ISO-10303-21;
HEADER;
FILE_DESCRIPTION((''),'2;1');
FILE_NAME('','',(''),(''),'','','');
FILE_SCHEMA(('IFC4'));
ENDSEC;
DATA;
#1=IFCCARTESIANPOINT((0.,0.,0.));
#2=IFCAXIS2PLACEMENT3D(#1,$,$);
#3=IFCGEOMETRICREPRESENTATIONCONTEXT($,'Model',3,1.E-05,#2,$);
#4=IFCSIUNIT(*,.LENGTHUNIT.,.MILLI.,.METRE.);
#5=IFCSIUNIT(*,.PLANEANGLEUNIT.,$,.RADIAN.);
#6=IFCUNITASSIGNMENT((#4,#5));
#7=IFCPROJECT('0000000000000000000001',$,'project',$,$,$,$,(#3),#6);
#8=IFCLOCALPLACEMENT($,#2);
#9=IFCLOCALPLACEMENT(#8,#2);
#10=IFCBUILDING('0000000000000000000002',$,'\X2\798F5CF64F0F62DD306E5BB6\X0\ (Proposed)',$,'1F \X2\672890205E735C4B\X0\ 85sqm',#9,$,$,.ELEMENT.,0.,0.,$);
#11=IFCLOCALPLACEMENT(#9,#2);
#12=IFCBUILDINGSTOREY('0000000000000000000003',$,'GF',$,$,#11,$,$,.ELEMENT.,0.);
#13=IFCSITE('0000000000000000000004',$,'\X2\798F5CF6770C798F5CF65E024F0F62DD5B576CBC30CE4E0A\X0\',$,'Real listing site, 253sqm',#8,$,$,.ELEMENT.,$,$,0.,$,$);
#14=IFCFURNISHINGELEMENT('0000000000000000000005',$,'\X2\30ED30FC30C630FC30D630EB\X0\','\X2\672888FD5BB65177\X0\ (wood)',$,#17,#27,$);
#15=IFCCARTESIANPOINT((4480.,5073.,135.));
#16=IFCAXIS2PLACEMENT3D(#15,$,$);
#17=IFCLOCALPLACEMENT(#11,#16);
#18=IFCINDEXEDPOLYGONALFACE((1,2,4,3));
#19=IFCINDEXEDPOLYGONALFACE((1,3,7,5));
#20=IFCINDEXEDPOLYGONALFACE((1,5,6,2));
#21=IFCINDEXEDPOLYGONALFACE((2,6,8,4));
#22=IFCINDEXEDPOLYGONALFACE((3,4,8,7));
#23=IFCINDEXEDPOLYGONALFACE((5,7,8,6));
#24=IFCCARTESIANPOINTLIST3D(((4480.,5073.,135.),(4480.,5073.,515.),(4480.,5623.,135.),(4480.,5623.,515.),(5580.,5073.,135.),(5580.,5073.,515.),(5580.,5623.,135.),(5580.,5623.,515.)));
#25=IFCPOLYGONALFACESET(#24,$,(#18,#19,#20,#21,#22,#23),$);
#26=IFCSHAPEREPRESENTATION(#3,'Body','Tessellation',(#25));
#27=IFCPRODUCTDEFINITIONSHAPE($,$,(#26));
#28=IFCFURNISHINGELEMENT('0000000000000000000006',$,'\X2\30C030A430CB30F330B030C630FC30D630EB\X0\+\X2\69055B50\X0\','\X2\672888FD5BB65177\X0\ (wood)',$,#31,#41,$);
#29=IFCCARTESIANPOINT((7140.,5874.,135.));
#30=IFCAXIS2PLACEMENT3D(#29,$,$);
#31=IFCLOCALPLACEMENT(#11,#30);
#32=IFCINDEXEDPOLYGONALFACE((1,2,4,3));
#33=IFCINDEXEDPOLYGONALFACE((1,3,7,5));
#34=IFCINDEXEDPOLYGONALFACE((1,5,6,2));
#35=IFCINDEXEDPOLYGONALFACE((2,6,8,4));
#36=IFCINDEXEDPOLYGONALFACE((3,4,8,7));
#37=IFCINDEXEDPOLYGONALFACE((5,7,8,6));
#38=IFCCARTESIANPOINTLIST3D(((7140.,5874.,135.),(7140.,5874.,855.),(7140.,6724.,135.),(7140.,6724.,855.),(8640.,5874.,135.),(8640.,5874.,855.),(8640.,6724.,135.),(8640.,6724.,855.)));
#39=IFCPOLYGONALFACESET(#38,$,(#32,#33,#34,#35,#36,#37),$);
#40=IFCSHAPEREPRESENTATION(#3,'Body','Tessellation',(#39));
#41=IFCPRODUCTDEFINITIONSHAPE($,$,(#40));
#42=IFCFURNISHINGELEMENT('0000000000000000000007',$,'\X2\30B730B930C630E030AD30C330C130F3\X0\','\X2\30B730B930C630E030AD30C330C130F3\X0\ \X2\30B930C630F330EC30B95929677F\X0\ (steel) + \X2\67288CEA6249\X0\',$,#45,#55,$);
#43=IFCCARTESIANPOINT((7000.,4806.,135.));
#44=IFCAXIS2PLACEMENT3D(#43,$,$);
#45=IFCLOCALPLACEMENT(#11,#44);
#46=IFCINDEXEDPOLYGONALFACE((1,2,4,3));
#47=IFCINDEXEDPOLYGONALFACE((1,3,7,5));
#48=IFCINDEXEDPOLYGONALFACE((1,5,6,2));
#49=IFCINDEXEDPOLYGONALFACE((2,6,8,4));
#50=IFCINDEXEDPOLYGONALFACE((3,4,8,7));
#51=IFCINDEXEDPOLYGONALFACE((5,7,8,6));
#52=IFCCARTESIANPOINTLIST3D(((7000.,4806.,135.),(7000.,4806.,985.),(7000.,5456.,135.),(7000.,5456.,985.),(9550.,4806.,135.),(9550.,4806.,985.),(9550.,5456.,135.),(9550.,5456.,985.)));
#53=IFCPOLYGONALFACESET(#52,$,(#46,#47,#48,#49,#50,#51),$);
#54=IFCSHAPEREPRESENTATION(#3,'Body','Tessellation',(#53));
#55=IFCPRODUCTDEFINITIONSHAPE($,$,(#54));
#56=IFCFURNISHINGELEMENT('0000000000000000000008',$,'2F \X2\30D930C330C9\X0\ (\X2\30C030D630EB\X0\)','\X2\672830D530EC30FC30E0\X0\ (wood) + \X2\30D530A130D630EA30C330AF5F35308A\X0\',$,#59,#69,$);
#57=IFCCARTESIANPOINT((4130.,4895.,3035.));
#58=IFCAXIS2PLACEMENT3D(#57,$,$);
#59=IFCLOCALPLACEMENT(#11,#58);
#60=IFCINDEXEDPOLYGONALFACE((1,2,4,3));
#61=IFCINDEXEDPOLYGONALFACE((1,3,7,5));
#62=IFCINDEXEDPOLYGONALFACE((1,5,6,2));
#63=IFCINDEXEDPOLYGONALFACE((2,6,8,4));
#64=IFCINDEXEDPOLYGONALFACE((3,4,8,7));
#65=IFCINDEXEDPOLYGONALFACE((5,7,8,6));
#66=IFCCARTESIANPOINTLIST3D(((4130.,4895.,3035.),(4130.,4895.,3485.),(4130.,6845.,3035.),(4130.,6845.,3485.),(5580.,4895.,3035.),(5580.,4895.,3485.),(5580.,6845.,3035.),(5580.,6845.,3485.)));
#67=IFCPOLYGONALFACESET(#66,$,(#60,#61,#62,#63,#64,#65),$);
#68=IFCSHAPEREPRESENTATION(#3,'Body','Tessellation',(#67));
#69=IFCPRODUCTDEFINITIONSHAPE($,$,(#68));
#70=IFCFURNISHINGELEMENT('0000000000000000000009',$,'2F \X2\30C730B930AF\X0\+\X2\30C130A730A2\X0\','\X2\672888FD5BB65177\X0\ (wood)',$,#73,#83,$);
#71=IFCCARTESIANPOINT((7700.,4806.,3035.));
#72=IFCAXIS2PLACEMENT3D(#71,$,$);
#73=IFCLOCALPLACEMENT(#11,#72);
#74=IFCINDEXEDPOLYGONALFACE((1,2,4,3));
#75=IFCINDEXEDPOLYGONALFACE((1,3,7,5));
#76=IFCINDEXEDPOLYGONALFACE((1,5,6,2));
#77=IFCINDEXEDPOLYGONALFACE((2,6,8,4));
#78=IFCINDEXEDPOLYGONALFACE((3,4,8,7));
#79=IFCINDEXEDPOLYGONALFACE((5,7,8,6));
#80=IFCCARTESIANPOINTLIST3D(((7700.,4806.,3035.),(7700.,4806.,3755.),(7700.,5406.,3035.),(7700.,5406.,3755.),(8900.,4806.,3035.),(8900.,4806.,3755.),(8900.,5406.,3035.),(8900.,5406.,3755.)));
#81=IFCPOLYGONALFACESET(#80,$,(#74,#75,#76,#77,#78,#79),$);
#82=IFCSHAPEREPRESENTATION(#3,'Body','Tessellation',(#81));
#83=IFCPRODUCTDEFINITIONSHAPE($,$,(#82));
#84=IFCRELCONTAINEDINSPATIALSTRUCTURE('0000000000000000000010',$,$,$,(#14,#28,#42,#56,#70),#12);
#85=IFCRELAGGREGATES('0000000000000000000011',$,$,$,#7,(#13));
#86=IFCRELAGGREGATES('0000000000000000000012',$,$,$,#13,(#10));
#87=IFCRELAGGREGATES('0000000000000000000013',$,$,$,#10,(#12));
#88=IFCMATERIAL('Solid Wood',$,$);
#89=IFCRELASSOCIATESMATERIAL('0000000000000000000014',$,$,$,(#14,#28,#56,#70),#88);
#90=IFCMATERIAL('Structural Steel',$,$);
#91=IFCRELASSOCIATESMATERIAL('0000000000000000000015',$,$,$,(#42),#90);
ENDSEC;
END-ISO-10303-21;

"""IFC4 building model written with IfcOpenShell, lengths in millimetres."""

from ifc_helpers import new_model, si_unit, frame, frame_2d, origin, place, context, project, spatial, rectangle, extrude, material, element, save


model = new_model("IFC4")

# Units and contexts
model_context = context("Model", 3, precision=1e-05, world=origin())
ifc_project = project(units=[si_unit("LENGTHUNIT", "METRE", prefix="MILLI"), si_unit("PLANEANGLEUNIT", "RADIAN")], contexts=[model_context])

# Site, building, storey
site_placement = place(None, origin())
site = spatial("IfcSite", under=ifc_project, at=site_placement, Name="福島県福島市伏拝字沼ノ上", ObjectType="Real listing site, 253sqm", CompositionType="ELEMENT", RefElevation=0.0)
building_placement = place(site_placement, origin())
building = spatial("IfcBuilding", under=site, at=building_placement, Name="福島伏拝の家 (Proposed)", ObjectType="1F 木造平屋 85sqm", CompositionType="ELEMENT", ElevationOfRefHeight=0.0, ElevationOfTerrain=0.0)
storey_placement = place(building_placement, origin())
storey = spatial("IfcBuildingStorey", under=building, at=storey_placement, Name="GF", CompositionType="ELEMENT", Elevation=0.0)

# Shared definitions
ifc_material_1 = material(Name="Solid Wood")

# Shared definitions
ifc_material_2 = material(Name="Structural Steel")

# Furnishing elements
furnishing_1_placement = place(storey_placement, frame((4480.0, 5073.0, 135.0)))
element("IfcFurnishingElement", 1, at=furnishing_1_placement, inside=storey, material=ifc_material_1, Name="ローテーブル", Description="木製家具 (wood)", context=model_context, shape_type="SweptSolid", body=[
    extrude(rectangle(XDim=1100.0, YDim=550.0, at=frame_2d((550.0, 275.0))), frame((4480.0, 5073.0, 135.0)), (0.0, 0.0, 1.0), 380.0),
])
furnishing_2_placement = place(storey_placement, frame((7140.0, 5874.0, 135.0)))
element("IfcFurnishingElement", 2, at=furnishing_2_placement, inside=storey, material=ifc_material_1, Name="ダイニングテーブル+椅子", Description="木製家具 (wood)", context=model_context, shape_type="SweptSolid", body=[
    extrude(rectangle(XDim=1500.0, YDim=850.0, at=frame_2d((750.0, 425.0))), frame((7140.0, 5874.0, 135.0)), (0.0, 0.0, 1.0), 720.0),
])
furnishing_3_placement = place(storey_placement, frame((7000.0, 4806.0, 135.0)))
element("IfcFurnishingElement", 3, at=furnishing_3_placement, inside=storey, material=ifc_material_2, Name="システムキッチン", Description="システムキッチン ステンレス天板 (steel) + 木質扉", context=model_context, shape_type="SweptSolid", body=[
    extrude(rectangle(XDim=2550.0, YDim=650.0, at=frame_2d((1275.0, 325.0))), frame((7000.0, 4806.0, 135.0)), (0.0, 0.0, 1.0), 850.0),
])
furnishing_4_placement = place(storey_placement, frame((4130.0, 4895.0, 3035.0)))
element("IfcFurnishingElement", 4, at=furnishing_4_placement, inside=storey, material=ifc_material_1, Name="2F ベッド (ダブル)", Description="木フレーム (wood) + ファブリック張り", context=model_context, shape_type="SweptSolid", body=[
    extrude(rectangle(XDim=1450.0, YDim=1950.0, at=frame_2d((725.0, 975.0))), frame((4130.0, 4895.0, 3035.0)), (0.0, 0.0, 1.0), 450.0),
])
furnishing_5_placement = place(storey_placement, frame((7700.0, 4806.0, 3035.0)))
element("IfcFurnishingElement", 5, at=furnishing_5_placement, inside=storey, material=ifc_material_1, Name="2F デスク+チェア", Description="木製家具 (wood)", context=model_context, shape_type="SweptSolid", body=[
    extrude(rectangle(XDim=1200.0, YDim=600.0, at=frame_2d((600.0, 300.0))), frame((7700.0, 4806.0, 3035.0)), (0.0, 0.0, 1.0), 720.0),
])

save(model, "model.ifc")
